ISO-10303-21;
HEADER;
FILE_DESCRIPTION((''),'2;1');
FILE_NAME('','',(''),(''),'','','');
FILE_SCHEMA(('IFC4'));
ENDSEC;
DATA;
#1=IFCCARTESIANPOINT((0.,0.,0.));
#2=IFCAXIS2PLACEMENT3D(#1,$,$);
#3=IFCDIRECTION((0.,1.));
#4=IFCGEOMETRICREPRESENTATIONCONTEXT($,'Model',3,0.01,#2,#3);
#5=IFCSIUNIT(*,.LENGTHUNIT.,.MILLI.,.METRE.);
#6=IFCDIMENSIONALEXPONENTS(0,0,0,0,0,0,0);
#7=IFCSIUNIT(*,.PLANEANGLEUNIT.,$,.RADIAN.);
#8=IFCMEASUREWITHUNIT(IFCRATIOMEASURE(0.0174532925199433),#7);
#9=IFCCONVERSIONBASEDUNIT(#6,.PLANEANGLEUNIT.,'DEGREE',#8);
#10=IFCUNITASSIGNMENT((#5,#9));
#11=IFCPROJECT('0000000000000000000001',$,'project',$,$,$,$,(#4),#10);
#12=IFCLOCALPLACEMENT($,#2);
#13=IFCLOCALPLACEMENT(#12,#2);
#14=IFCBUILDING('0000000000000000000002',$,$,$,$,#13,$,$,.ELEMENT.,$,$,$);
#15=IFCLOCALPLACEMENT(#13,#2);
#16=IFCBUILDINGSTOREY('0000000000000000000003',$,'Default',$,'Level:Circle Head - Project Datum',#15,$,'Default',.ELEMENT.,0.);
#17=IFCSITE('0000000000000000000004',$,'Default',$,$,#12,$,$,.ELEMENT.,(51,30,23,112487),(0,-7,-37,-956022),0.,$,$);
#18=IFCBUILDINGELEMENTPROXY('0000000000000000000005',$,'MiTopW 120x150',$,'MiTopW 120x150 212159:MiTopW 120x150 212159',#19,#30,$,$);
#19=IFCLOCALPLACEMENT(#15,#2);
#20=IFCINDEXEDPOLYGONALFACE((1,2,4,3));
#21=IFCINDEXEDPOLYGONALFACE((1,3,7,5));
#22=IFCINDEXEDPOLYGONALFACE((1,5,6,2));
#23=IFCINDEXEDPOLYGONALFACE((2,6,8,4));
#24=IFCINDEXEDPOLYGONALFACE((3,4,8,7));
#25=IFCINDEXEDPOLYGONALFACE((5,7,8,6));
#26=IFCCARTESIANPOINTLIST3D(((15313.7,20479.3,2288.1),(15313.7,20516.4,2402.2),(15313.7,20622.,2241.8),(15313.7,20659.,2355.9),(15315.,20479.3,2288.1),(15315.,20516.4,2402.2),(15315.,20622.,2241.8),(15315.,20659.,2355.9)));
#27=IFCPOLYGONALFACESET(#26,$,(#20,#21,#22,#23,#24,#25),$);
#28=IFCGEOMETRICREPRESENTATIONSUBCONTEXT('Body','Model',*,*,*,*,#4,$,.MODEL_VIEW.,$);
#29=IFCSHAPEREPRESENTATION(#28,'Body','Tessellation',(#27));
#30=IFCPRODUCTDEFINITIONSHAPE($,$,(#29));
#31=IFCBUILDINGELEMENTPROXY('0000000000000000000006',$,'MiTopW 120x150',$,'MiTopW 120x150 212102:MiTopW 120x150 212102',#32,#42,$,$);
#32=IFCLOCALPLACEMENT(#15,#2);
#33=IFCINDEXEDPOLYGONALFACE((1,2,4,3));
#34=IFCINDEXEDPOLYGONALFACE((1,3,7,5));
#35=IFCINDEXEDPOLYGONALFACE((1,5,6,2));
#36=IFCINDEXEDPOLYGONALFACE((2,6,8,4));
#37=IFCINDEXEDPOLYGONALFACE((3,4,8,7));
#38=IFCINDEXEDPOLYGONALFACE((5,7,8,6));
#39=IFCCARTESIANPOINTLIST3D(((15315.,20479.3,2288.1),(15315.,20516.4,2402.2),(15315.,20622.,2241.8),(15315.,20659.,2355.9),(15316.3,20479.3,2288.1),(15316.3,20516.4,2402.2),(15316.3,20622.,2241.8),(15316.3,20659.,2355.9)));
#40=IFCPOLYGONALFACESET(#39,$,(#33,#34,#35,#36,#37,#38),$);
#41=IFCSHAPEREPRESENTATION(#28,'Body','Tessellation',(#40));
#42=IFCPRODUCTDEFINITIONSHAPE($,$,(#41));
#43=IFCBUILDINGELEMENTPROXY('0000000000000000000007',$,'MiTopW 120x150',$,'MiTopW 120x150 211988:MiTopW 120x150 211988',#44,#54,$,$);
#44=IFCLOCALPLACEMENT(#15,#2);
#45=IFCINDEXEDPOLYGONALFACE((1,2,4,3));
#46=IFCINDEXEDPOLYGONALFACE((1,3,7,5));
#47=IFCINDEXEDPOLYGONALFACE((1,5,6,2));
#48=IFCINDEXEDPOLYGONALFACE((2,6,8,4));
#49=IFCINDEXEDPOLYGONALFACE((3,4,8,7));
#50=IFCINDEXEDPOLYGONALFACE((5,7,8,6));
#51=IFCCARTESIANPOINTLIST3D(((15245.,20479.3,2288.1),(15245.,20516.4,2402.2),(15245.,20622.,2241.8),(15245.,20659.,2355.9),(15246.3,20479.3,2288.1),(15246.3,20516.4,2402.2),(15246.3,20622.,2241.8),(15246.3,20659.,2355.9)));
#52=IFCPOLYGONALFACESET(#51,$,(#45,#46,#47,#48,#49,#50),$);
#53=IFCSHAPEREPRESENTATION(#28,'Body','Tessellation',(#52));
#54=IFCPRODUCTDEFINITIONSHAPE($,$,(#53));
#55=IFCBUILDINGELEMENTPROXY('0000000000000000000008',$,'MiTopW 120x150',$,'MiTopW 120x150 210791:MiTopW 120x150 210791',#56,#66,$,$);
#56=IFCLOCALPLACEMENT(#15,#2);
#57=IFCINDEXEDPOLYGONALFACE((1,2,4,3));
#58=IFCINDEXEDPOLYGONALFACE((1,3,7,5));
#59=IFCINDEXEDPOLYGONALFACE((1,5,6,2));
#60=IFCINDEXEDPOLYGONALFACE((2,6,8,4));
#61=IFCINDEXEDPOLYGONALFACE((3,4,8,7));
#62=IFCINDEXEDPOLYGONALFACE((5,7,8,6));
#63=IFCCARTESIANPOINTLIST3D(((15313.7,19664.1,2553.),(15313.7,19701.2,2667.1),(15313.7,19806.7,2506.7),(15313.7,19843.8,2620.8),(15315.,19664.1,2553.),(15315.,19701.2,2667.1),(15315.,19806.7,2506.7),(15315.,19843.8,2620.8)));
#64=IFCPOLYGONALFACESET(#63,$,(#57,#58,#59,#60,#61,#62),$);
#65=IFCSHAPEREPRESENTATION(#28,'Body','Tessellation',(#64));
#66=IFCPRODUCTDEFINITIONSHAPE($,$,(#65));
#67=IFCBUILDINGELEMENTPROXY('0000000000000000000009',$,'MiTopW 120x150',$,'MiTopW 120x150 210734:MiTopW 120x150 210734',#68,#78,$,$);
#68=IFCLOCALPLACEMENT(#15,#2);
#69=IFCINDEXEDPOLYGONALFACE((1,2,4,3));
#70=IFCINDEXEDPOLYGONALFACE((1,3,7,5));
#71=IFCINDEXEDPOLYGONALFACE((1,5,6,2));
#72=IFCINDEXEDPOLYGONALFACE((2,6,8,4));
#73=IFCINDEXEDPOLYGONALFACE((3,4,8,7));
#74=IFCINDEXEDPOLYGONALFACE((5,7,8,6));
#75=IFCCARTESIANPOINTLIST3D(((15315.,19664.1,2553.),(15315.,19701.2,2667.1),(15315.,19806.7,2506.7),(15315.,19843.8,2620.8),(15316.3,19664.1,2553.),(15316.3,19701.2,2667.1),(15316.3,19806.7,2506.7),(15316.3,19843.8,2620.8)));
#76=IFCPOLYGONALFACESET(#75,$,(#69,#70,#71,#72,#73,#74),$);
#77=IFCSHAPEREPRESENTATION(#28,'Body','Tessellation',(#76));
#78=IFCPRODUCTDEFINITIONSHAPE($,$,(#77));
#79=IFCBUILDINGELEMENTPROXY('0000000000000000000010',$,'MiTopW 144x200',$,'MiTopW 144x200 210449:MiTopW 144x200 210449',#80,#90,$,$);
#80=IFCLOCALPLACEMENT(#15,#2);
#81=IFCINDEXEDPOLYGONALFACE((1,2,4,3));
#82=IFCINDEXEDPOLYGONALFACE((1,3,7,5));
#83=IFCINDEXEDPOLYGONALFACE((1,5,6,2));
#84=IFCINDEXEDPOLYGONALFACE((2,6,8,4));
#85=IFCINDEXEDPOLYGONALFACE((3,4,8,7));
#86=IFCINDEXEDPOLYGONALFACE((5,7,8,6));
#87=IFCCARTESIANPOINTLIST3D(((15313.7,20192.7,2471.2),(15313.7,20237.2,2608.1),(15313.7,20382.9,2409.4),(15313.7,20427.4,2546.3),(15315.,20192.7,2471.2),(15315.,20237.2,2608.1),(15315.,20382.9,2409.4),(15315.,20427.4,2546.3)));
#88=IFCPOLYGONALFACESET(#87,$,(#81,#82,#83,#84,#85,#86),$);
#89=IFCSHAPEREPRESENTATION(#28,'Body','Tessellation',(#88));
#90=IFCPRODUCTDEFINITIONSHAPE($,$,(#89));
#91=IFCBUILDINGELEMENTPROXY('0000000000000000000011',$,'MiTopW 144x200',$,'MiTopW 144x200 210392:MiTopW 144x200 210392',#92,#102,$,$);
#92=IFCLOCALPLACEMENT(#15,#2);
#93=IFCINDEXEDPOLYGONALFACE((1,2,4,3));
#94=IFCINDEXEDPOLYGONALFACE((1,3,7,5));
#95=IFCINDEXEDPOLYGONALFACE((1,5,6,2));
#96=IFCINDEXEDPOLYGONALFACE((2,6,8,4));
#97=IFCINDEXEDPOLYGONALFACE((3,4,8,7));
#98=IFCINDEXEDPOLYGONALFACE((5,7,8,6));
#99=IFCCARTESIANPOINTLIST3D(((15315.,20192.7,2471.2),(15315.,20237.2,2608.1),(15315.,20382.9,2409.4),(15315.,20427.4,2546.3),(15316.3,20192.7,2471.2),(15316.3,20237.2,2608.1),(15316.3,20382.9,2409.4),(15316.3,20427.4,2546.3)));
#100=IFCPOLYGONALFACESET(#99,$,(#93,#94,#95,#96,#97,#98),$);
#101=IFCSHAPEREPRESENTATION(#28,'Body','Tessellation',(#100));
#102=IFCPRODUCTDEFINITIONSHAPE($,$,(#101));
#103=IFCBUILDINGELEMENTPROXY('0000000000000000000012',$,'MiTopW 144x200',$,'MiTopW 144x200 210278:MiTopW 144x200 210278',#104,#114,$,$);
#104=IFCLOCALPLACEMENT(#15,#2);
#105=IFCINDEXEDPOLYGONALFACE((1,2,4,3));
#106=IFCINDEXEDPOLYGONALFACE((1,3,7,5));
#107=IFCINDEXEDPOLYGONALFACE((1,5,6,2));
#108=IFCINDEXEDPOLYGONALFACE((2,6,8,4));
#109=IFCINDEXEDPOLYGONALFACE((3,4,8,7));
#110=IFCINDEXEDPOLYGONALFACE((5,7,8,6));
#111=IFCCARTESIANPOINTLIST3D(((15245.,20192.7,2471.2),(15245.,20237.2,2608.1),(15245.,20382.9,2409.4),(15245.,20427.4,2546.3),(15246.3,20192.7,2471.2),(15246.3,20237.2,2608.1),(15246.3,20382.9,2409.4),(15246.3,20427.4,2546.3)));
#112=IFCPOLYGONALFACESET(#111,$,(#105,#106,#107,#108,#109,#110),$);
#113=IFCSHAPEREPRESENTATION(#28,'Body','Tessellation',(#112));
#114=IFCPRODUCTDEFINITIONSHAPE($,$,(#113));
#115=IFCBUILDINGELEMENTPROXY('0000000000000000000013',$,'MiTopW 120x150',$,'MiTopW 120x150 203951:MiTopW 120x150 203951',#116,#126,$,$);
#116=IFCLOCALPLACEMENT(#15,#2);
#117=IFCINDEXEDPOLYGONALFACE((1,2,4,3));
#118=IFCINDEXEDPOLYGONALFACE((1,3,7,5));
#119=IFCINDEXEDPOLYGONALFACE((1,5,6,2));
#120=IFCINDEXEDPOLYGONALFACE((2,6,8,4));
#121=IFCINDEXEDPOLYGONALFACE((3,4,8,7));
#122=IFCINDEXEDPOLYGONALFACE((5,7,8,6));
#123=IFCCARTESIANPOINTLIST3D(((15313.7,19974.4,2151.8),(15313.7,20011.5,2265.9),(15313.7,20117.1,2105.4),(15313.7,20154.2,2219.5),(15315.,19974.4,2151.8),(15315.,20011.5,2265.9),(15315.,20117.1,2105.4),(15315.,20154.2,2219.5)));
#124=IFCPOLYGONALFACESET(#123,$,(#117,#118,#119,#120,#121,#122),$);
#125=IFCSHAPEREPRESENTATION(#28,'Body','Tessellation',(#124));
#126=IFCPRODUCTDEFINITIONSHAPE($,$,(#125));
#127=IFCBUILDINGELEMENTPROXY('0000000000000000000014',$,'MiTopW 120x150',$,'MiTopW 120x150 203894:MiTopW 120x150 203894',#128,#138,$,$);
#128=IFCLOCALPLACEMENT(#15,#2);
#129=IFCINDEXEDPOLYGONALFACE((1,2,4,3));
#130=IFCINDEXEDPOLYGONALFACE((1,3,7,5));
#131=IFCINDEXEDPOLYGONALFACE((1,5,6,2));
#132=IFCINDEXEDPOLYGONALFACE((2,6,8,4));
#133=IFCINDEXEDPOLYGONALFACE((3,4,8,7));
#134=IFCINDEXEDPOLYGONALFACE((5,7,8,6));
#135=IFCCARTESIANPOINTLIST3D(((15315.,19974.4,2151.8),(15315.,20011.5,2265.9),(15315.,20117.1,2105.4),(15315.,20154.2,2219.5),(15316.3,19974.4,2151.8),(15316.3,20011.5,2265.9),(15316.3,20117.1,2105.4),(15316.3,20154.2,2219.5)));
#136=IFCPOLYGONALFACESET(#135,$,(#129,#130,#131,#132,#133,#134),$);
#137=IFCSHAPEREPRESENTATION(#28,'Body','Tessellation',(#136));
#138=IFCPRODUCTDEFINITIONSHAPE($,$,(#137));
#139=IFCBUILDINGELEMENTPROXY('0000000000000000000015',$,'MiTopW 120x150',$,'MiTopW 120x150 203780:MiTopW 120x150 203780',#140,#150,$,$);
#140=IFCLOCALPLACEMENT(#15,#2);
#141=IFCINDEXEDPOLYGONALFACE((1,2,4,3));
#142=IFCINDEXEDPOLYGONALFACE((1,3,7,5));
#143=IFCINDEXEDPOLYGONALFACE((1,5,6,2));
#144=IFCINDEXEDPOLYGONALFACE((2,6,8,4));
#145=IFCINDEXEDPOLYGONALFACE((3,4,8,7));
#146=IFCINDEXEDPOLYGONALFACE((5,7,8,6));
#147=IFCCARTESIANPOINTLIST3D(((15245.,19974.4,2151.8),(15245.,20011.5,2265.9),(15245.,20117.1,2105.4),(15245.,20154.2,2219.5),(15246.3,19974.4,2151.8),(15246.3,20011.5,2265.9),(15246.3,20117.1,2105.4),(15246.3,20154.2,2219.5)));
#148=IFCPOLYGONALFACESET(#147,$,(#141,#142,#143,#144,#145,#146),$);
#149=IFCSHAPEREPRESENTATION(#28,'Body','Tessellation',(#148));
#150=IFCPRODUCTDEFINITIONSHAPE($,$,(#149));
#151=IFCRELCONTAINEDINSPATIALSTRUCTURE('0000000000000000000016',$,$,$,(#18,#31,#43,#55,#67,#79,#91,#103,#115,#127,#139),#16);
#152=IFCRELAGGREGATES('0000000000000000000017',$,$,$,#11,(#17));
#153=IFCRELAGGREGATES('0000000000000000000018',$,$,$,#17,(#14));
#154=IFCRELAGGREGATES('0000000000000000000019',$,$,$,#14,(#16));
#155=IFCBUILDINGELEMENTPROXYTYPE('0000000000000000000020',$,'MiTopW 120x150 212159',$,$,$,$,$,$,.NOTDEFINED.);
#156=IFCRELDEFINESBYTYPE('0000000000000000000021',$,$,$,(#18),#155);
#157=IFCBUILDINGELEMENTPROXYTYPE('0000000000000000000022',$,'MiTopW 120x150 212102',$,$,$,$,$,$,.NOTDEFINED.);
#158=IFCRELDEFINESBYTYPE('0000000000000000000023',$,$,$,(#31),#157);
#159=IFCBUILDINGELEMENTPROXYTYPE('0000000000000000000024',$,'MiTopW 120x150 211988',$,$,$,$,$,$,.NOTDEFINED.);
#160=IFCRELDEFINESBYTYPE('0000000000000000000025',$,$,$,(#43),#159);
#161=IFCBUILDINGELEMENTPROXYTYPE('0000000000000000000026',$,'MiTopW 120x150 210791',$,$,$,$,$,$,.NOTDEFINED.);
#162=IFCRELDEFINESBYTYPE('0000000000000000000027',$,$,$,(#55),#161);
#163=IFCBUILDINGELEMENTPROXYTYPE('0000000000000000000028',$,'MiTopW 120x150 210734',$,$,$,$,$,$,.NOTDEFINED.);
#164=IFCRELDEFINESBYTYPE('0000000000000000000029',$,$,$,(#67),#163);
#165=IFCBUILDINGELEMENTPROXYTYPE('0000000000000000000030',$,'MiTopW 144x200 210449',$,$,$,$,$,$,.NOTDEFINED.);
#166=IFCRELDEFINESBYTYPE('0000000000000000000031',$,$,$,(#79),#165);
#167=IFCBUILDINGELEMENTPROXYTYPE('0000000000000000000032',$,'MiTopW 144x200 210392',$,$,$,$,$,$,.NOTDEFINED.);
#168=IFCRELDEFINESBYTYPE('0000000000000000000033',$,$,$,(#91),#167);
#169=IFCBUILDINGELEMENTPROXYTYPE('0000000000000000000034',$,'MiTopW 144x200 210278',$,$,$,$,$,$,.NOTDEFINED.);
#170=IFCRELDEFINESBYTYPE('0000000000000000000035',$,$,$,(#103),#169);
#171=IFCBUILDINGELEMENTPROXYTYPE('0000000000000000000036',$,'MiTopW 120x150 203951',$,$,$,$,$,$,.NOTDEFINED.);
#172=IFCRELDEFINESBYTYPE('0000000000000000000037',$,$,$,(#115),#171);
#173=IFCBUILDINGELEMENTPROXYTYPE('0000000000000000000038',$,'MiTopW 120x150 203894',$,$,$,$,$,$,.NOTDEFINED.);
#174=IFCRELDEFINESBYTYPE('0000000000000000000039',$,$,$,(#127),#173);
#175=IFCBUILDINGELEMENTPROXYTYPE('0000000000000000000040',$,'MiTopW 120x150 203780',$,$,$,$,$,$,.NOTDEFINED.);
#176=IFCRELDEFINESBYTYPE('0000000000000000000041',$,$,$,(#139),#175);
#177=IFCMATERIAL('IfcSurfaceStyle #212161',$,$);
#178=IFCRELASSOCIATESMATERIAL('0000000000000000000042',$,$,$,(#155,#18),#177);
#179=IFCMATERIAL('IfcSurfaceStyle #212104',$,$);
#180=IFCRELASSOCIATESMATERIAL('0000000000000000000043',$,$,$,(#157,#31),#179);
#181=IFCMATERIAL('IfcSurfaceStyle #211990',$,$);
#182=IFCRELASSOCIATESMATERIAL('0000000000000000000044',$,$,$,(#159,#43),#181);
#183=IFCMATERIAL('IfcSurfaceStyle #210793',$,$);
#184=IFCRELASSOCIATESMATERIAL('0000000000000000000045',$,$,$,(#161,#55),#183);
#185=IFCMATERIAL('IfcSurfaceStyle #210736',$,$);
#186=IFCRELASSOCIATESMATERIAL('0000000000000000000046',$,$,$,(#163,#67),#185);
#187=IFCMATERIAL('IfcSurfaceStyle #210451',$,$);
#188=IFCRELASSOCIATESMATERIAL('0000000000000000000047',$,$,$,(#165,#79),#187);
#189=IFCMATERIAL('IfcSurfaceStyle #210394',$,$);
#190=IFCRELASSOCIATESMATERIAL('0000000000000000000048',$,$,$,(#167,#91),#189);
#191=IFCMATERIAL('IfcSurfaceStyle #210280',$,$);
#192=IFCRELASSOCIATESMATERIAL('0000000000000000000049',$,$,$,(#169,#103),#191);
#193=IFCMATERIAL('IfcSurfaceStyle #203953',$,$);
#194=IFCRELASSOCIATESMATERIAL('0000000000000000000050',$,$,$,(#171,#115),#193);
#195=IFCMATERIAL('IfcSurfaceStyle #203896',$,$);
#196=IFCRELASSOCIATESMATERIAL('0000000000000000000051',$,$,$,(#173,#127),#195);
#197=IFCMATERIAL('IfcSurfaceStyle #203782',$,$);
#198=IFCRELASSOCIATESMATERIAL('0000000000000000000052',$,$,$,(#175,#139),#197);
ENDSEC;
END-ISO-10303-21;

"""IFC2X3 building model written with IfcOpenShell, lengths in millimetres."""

from ifc_helpers import new_model, entity, si_unit, converted_unit, direction, frame, origin, place, context, subcontext, project, spatial, polyline, outline, extrude, source, transform, mapped, material, type_object, type_shapes, element, save


model = new_model("IFC2X3")

# Units and contexts
model_context = context("Model", 3, precision=0.01, world=origin(), true_north=direction((0.0, 1.0)))
body_context = subcontext(model_context, "Body", "Model", "MODEL_VIEW")
ifc_project = project(units=[si_unit("LENGTHUNIT", "METRE", prefix="MILLI"), converted_unit("PLANEANGLEUNIT", "DEGREE", entity("IfcRatioMeasure", 0.0174532925199433), si_unit("PLANEANGLEUNIT", "RADIAN"), dimensions=[0, 0, 0, 0, 0, 0, 0])], contexts=[model_context])

# Site, building, storey
site_placement = place(None, origin())
site = spatial("IfcSite", under=ifc_project, at=site_placement, Name="Default", CompositionType="ELEMENT", RefLatitude=(51, 30, 23, 112487), RefLongitude=(0, -7, -37, -956022), RefElevation=0.0)
building_placement = place(site_placement, origin())
building = spatial("IfcBuilding", under=site, at=building_placement, CompositionType="ELEMENT")
storey_placement = place(building_placement, origin())
storey = spatial("IfcBuildingStorey", under=building, at=storey_placement, Name="Default", ObjectType="Level:Circle Head - Project Datum", LongName="Default", CompositionType="ELEMENT", Elevation=0.0)

# Building element proxies
ifc_material_1 = material(Name="IfcSurfaceStyle #212161")
building_element_proxy_type_1 = type_object("IfcBuildingElementProxyType", Name="MiTopW 120x150 212159", PredefinedType="NOTDEFINED", material=ifc_material_1)
shared_shape_1 = source(origin(), body_context, "Body", "SweptSolid", [
    extrude(outline(polyline([(-75.0, -60.0), (75.0, -60.0), (75.0, 60.0), (-75.0, 60.0), (-75.0, -60.0)])), frame((75.0, 60.0, 0.0), z_axis=(0.0, 0.0, 1.0), x_axis=(-1.0, 0.0, 0.0)), (0.0, 0.0, 1.0), 1.3),
])
type_shapes(building_element_proxy_type_1, [shared_shape_1])
proxy_1_placement = place(building_placement, frame((15315.0, 20622.0, 2241.8), z_axis=(-1.0, 0.0, 0.0), x_axis=(0.0, -0.951057, 0.309017)))
element("IfcBuildingElementProxy", 1, at=proxy_1_placement, inside=storey, type_object=building_element_proxy_type_1, material=ifc_material_1, Name="MiTopW 120x150", ObjectType="MiTopW 120x150 212159:MiTopW 120x150 212159", context=body_context, shape_type="MappedRepresentation", body=[
    mapped(shared_shape_1, transform((0.0, 0.0, 0.0), scale=1.0)),
])
ifc_material_2 = material(Name="IfcSurfaceStyle #212104")
building_element_proxy_type_2 = type_object("IfcBuildingElementProxyType", Name="MiTopW 120x150 212102", PredefinedType="NOTDEFINED", material=ifc_material_2)
shared_shape_2 = source(origin(), body_context, "Body", "SweptSolid", [
    extrude(outline(polyline([(-75.0, -60.0), (75.0, -60.0), (75.0, 60.0), (-75.0, 60.0), (-75.0, -60.0)])), frame((75.0, 60.0, 0.0), z_axis=(0.0, 0.0, 1.0), x_axis=(-1.0, 0.0, 0.0)), (0.0, 0.0, 1.0), 1.3),
])
type_shapes(building_element_proxy_type_2, [shared_shape_2])
proxy_2_placement = place(building_placement, frame((15316.3, 20622.0, 2241.8), z_axis=(-1.0, 0.0, 0.0), x_axis=(0.0, -0.951057, 0.309017)))
element("IfcBuildingElementProxy", 2, at=proxy_2_placement, inside=storey, type_object=building_element_proxy_type_2, material=ifc_material_2, Name="MiTopW 120x150", ObjectType="MiTopW 120x150 212102:MiTopW 120x150 212102", context=body_context, shape_type="MappedRepresentation", body=[
    mapped(shared_shape_2, transform((0.0, 0.0, 0.0), scale=1.0)),
])
ifc_material_3 = material(Name="IfcSurfaceStyle #211990")
building_element_proxy_type_3 = type_object("IfcBuildingElementProxyType", Name="MiTopW 120x150 211988", PredefinedType="NOTDEFINED", material=ifc_material_3)
shared_shape_3 = source(origin(), body_context, "Body", "SweptSolid", [
    extrude(outline(polyline([(-75.0, -60.0), (75.0, -60.0), (75.0, 60.0), (-75.0, 60.0), (-75.0, -60.0)])), frame((75.0, 60.0, 0.0), z_axis=(0.0, 0.0, 1.0), x_axis=(-1.0, 0.0, 0.0)), (0.0, 0.0, 1.0), 1.3),
])
type_shapes(building_element_proxy_type_3, [shared_shape_3])
proxy_3_placement = place(building_placement, frame((15246.3, 20622.0, 2241.8), z_axis=(-1.0, 0.0, 0.0), x_axis=(0.0, -0.951057, 0.309017)))
element("IfcBuildingElementProxy", 3, at=proxy_3_placement, inside=storey, type_object=building_element_proxy_type_3, material=ifc_material_3, Name="MiTopW 120x150", ObjectType="MiTopW 120x150 211988:MiTopW 120x150 211988", context=body_context, shape_type="MappedRepresentation", body=[
    mapped(shared_shape_3, transform((0.0, 0.0, 0.0), scale=1.0)),
])
ifc_material_4 = material(Name="IfcSurfaceStyle #210793")
building_element_proxy_type_4 = type_object("IfcBuildingElementProxyType", Name="MiTopW 120x150 210791", PredefinedType="NOTDEFINED", material=ifc_material_4)
shared_shape_4 = source(origin(), body_context, "Body", "SweptSolid", [
    extrude(outline(polyline([(-75.0, -60.0), (75.0, -60.0), (75.0, 60.0), (-75.0, 60.0), (-75.0, -60.0)])), frame((75.0, 60.0, 0.0), z_axis=(0.0, 0.0, 1.0), x_axis=(-1.0, 0.0, 0.0)), (0.0, 0.0, 1.0), 1.3),
])
type_shapes(building_element_proxy_type_4, [shared_shape_4])
proxy_4_placement = place(building_placement, frame((15315.0, 19806.7, 2506.7), z_axis=(-1.0, 0.0, 0.0), x_axis=(0.0, -0.951057, 0.309017)))
element("IfcBuildingElementProxy", 4, at=proxy_4_placement, inside=storey, type_object=building_element_proxy_type_4, material=ifc_material_4, Name="MiTopW 120x150", ObjectType="MiTopW 120x150 210791:MiTopW 120x150 210791", context=body_context, shape_type="MappedRepresentation", body=[
    mapped(shared_shape_4, transform((0.0, 0.0, 0.0), scale=1.0)),
])
ifc_material_5 = material(Name="IfcSurfaceStyle #210736")
building_element_proxy_type_5 = type_object("IfcBuildingElementProxyType", Name="MiTopW 120x150 210734", PredefinedType="NOTDEFINED", material=ifc_material_5)
shared_shape_5 = source(origin(), body_context, "Body", "SweptSolid", [
    extrude(outline(polyline([(-75.0, -60.0), (75.0, -60.0), (75.0, 60.0), (-75.0, 60.0), (-75.0, -60.0)])), frame((75.0, 60.0, 0.0), z_axis=(0.0, 0.0, 1.0), x_axis=(-1.0, 0.0, 0.0)), (0.0, 0.0, 1.0), 1.3),
])
type_shapes(building_element_proxy_type_5, [shared_shape_5])
proxy_5_placement = place(building_placement, frame((15316.3, 19806.7, 2506.7), z_axis=(-1.0, 0.0, 0.0), x_axis=(0.0, -0.951057, 0.309017)))
element("IfcBuildingElementProxy", 5, at=proxy_5_placement, inside=storey, type_object=building_element_proxy_type_5, material=ifc_material_5, Name="MiTopW 120x150", ObjectType="MiTopW 120x150 210734:MiTopW 120x150 210734", context=body_context, shape_type="MappedRepresentation", body=[
    mapped(shared_shape_5, transform((0.0, 0.0, 0.0), scale=1.0)),
])
ifc_material_6 = material(Name="IfcSurfaceStyle #210451")
building_element_proxy_type_6 = type_object("IfcBuildingElementProxyType", Name="MiTopW 144x200 210449", PredefinedType="NOTDEFINED", material=ifc_material_6)
shared_shape_6 = source(origin(), body_context, "Body", "SweptSolid", [
    extrude(outline(polyline([(-100.0, -72.0), (100.0, -72.0), (100.0, 72.0), (-100.0, 72.0), (-100.0, -72.0)])), frame((100.0, 72.0, 0.0), z_axis=(0.0, 0.0, 1.0), x_axis=(-1.0, 0.0, 0.0)), (0.0, 0.0, 1.0), 1.3),
])
type_shapes(building_element_proxy_type_6, [shared_shape_6])
proxy_6_placement = place(building_placement, frame((15315.0, 20382.9, 2409.4), z_axis=(-1.0, 0.0, 0.0), x_axis=(0.0, -0.951057, 0.309017)))
element("IfcBuildingElementProxy", 6, at=proxy_6_placement, inside=storey, type_object=building_element_proxy_type_6, material=ifc_material_6, Name="MiTopW 144x200", ObjectType="MiTopW 144x200 210449:MiTopW 144x200 210449", context=body_context, shape_type="MappedRepresentation", body=[
    mapped(shared_shape_6, transform((0.0, 0.0, 0.0), scale=1.0)),
])
ifc_material_7 = material(Name="IfcSurfaceStyle #210394")
building_element_proxy_type_7 = type_object("IfcBuildingElementProxyType", Name="MiTopW 144x200 210392", PredefinedType="NOTDEFINED", material=ifc_material_7)
shared_shape_7 = source(origin(), body_context, "Body", "SweptSolid", [
    extrude(outline(polyline([(-100.0, -72.0), (100.0, -72.0), (100.0, 72.0), (-100.0, 72.0), (-100.0, -72.0)])), frame((100.0, 72.0, 0.0), z_axis=(0.0, 0.0, 1.0), x_axis=(-1.0, 0.0, 0.0)), (0.0, 0.0, 1.0), 1.3),
])
type_shapes(building_element_proxy_type_7, [shared_shape_7])
proxy_7_placement = place(building_placement, frame((15316.3, 20382.9, 2409.4), z_axis=(-1.0, 0.0, 0.0), x_axis=(0.0, -0.951057, 0.309017)))
element("IfcBuildingElementProxy", 7, at=proxy_7_placement, inside=storey, type_object=building_element_proxy_type_7, material=ifc_material_7, Name="MiTopW 144x200", ObjectType="MiTopW 144x200 210392:MiTopW 144x200 210392", context=body_context, shape_type="MappedRepresentation", body=[
    mapped(shared_shape_7, transform((0.0, 0.0, 0.0), scale=1.0)),
])
ifc_material_8 = material(Name="IfcSurfaceStyle #210280")
building_element_proxy_type_8 = type_object("IfcBuildingElementProxyType", Name="MiTopW 144x200 210278", PredefinedType="NOTDEFINED", material=ifc_material_8)
shared_shape_8 = source(origin(), body_context, "Body", "SweptSolid", [
    extrude(outline(polyline([(-100.0, -72.0), (100.0, -72.0), (100.0, 72.0), (-100.0, 72.0), (-100.0, -72.0)])), frame((100.0, 72.0, 0.0), z_axis=(0.0, 0.0, 1.0), x_axis=(-1.0, 0.0, 0.0)), (0.0, 0.0, 1.0), 1.3),
])
type_shapes(building_element_proxy_type_8, [shared_shape_8])
proxy_8_placement = place(building_placement, frame((15246.3, 20382.9, 2409.4), z_axis=(-1.0, 0.0, 0.0), x_axis=(0.0, -0.951057, 0.309017)))
element("IfcBuildingElementProxy", 8, at=proxy_8_placement, inside=storey, type_object=building_element_proxy_type_8, material=ifc_material_8, Name="MiTopW 144x200", ObjectType="MiTopW 144x200 210278:MiTopW 144x200 210278", context=body_context, shape_type="MappedRepresentation", body=[
    mapped(shared_shape_8, transform((0.0, 0.0, 0.0), scale=1.0)),
])
ifc_material_9 = material(Name="IfcSurfaceStyle #203953")
building_element_proxy_type_9 = type_object("IfcBuildingElementProxyType", Name="MiTopW 120x150 203951", PredefinedType="NOTDEFINED", material=ifc_material_9)
shared_shape_9 = source(origin(), body_context, "Body", "SweptSolid", [
    extrude(outline(polyline([(-75.0, -60.0), (75.0, -60.0), (75.0, 60.0), (-75.0, 60.0), (-75.0, -60.0)])), frame((75.0, 60.0, 0.0), z_axis=(0.0, 0.0, 1.0), x_axis=(-1.0, 0.0, 0.0)), (0.0, 0.0, 1.0), 1.3),
])
type_shapes(building_element_proxy_type_9, [shared_shape_9])
proxy_9_placement = place(building_placement, frame((15315.0, 20117.1, 2105.4), z_axis=(-1.0, 0.0, 0.0), x_axis=(0.0, -0.951057, 0.309017)))
element("IfcBuildingElementProxy", 9, at=proxy_9_placement, inside=storey, type_object=building_element_proxy_type_9, material=ifc_material_9, Name="MiTopW 120x150", ObjectType="MiTopW 120x150 203951:MiTopW 120x150 203951", context=body_context, shape_type="MappedRepresentation", body=[
    mapped(shared_shape_9, transform((0.0, 0.0, 0.0), scale=1.0)),
])
ifc_material_10 = material(Name="IfcSurfaceStyle #203896")
building_element_proxy_type_10 = type_object("IfcBuildingElementProxyType", Name="MiTopW 120x150 203894", PredefinedType="NOTDEFINED", material=ifc_material_10)
shared_shape_10 = source(origin(), body_context, "Body", "SweptSolid", [
    extrude(outline(polyline([(-75.0, -60.0), (75.0, -60.0), (75.0, 60.0), (-75.0, 60.0), (-75.0, -60.0)])), frame((75.0, 60.0, 0.0), z_axis=(0.0, 0.0, 1.0), x_axis=(-1.0, 0.0, 0.0)), (0.0, 0.0, 1.0), 1.3),
])
type_shapes(building_element_proxy_type_10, [shared_shape_10])
proxy_10_placement = place(building_placement, frame((15316.3, 20117.1, 2105.4), z_axis=(-1.0, 0.0, 0.0), x_axis=(0.0, -0.951057, 0.309017)))
element("IfcBuildingElementProxy", 10, at=proxy_10_placement, inside=storey, type_object=building_element_proxy_type_10, material=ifc_material_10, Name="MiTopW 120x150", ObjectType="MiTopW 120x150 203894:MiTopW 120x150 203894", context=body_context, shape_type="MappedRepresentation", body=[
    mapped(shared_shape_10, transform((0.0, 0.0, 0.0), scale=1.0)),
])
ifc_material_11 = material(Name="IfcSurfaceStyle #203782")
building_element_proxy_type_11 = type_object("IfcBuildingElementProxyType", Name="MiTopW 120x150 203780", PredefinedType="NOTDEFINED", material=ifc_material_11)
shared_shape_11 = source(origin(), body_context, "Body", "SweptSolid", [
    extrude(outline(polyline([(-75.0, -60.0), (75.0, -60.0), (75.0, 60.0), (-75.0, 60.0), (-75.0, -60.0)])), frame((75.0, 60.0, 0.0), z_axis=(0.0, 0.0, 1.0), x_axis=(-1.0, 0.0, 0.0)), (0.0, 0.0, 1.0), 1.3),
])
type_shapes(building_element_proxy_type_11, [shared_shape_11])
proxy_11_placement = place(building_placement, frame((15246.3, 20117.1, 2105.4), z_axis=(-1.0, 0.0, 0.0), x_axis=(0.0, -0.951057, 0.309017)))
element("IfcBuildingElementProxy", 11, at=proxy_11_placement, inside=storey, type_object=building_element_proxy_type_11, material=ifc_material_11, Name="MiTopW 120x150", ObjectType="MiTopW 120x150 203780:MiTopW 120x150 203780", context=body_context, shape_type="MappedRepresentation", body=[
    mapped(shared_shape_11, transform((0.0, 0.0, 0.0), scale=1.0)),
])

save(model, "model.ifc")
